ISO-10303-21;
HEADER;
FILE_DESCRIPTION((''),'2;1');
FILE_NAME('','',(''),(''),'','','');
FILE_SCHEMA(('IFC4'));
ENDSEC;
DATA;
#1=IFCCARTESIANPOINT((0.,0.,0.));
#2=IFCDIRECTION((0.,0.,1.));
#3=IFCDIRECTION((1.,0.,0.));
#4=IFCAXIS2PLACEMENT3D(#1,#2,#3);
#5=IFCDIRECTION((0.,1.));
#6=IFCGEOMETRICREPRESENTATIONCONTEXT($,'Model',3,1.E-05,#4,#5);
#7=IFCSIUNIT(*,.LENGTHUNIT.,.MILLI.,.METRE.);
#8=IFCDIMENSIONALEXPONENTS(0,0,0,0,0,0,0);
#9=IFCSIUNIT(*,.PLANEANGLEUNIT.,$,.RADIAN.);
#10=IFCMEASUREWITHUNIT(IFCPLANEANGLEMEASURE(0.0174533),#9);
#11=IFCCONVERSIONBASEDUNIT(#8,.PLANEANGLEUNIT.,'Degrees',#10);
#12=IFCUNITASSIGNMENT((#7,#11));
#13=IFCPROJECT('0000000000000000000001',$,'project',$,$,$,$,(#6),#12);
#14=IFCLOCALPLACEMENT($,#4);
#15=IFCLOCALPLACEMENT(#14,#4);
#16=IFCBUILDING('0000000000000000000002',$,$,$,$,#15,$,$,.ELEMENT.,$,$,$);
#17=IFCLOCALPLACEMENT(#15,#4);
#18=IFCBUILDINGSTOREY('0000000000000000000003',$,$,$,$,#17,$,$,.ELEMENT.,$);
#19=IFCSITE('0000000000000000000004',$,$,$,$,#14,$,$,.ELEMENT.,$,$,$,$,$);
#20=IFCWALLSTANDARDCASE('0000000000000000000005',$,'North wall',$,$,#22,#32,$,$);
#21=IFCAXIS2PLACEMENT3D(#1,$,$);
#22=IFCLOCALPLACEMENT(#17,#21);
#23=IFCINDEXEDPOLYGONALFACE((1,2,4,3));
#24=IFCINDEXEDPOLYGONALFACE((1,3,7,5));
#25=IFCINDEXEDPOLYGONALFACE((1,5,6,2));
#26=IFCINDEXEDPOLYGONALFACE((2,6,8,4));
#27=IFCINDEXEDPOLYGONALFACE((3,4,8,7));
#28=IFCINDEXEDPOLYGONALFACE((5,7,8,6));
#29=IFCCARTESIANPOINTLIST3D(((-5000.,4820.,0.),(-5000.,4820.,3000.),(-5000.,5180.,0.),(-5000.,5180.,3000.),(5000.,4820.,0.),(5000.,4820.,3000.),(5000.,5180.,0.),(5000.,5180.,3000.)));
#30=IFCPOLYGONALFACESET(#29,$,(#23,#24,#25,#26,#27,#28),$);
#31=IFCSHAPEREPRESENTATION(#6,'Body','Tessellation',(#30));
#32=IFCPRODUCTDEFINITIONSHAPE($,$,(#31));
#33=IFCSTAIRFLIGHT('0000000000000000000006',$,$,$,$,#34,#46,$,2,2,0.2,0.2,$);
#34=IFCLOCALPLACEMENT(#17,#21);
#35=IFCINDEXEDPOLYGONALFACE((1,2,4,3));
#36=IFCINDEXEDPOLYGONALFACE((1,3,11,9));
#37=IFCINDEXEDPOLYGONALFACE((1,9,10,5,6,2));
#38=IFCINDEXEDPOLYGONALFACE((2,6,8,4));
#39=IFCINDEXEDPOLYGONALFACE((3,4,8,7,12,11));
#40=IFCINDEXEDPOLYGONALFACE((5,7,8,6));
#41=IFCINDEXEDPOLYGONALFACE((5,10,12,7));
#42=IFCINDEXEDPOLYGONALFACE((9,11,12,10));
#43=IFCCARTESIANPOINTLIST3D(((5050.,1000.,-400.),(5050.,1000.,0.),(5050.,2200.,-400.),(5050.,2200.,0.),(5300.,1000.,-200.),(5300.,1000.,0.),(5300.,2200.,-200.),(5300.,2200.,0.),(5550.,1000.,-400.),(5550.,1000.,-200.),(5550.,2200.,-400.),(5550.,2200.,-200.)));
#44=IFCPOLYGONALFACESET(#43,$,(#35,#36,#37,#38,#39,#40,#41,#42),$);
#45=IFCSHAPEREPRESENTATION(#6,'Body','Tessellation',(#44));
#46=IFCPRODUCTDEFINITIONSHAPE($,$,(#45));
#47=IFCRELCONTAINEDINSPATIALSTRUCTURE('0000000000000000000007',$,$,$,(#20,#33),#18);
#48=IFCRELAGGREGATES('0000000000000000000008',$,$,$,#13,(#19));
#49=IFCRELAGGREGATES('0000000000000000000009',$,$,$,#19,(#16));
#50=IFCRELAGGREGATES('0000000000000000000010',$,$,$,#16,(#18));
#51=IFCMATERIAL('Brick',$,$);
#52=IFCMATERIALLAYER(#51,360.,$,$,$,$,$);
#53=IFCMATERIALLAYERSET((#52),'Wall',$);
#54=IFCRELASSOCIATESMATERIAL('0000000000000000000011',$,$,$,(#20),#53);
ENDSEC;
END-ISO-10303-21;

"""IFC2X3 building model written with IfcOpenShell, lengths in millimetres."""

from ifc_helpers import new_model, entity, si_unit, converted_unit, direction, frame, origin_with_axes, place, context, project, spatial, polyline, outline, extrude, material, layer, layer_set, layer_usage, element, save


model = new_model("IFC2X3")

# Units and contexts
model_context = context("Model", 3, precision=1e-05, world=origin_with_axes(), true_north=direction((0.0, 1.0)))
ifc_project = project(units=[si_unit("LENGTHUNIT", "METRE", prefix="MILLI"), converted_unit("PLANEANGLEUNIT", "Degrees", entity("IfcPlaneAngleMeasure", 0.0174533), si_unit("PLANEANGLEUNIT", "RADIAN"), dimensions=[0, 0, 0, 0, 0, 0, 0])], contexts=[model_context])

# Site, building, storey
site_placement = place(None, origin_with_axes())
site = spatial("IfcSite", under=ifc_project, at=site_placement, CompositionType="ELEMENT")
building_placement = place(site_placement, origin_with_axes())
building = spatial("IfcBuilding", under=site, at=building_placement, CompositionType="ELEMENT")
storey_placement = place(building_placement, origin_with_axes())
storey = spatial("IfcBuildingStorey", under=building, at=storey_placement, CompositionType="ELEMENT")

# Shared definitions
ifc_material = material(Name="Brick")
ifc_layer = layer(ifc_material, 360.0)
ifc_layer_set = layer_set([ifc_layer], Name="Wall")
ifc_layer_usage = layer_usage(ifc_layer_set, "AXIS2", "POSITIVE", -180.0)

# Wall
wall_1_placement = place(storey_placement, frame((0.0, 5000.0, 0.0), z_axis=(0.0, 0.0, 1.0), x_axis=(1.0, 0.0, 0.0)))
element("IfcWallStandardCase", 1, at=wall_1_placement, inside=storey, material=ifc_layer_usage, Name="North wall", context=model_context, shape_type="SweptSolid", body=[
    extrude(outline(polyline([(-5000.0, -180.0), (5000.0, -180.0), (5000.0, 180.0), (-5000.0, 180.0), (-5000.0, -180.0), (-5000.0, -180.0)])), origin_with_axes(), (0.0, 0.0, 1.0), 3000.0),
])

# Stair flight
stair_flight_placement = place(storey_placement, frame((5050.0, 1000.0, 0.0), z_axis=(0.0, 1.0, 0.0), x_axis=(1.0, 0.0, 0.0)))
element("IfcStairFlight", 2, at=stair_flight_placement, inside=storey, NumberOfRiser=2, NumberOfTreads=2, RiserHeight=0.2, TreadLength=0.2, context=model_context, shape_type="SweptSolid", body=[
    extrude(outline(polyline([(0.0, 0.0), (250.0, 0.0), (250.0, 200.0), (500.0, 200.0), (500.0, 400.0), (0.0, 400.0), (0.0, 0.0)])), origin_with_axes(), (0.0, 0.0, 1.0), 1200.0),
])

save(model, "model.ifc")
